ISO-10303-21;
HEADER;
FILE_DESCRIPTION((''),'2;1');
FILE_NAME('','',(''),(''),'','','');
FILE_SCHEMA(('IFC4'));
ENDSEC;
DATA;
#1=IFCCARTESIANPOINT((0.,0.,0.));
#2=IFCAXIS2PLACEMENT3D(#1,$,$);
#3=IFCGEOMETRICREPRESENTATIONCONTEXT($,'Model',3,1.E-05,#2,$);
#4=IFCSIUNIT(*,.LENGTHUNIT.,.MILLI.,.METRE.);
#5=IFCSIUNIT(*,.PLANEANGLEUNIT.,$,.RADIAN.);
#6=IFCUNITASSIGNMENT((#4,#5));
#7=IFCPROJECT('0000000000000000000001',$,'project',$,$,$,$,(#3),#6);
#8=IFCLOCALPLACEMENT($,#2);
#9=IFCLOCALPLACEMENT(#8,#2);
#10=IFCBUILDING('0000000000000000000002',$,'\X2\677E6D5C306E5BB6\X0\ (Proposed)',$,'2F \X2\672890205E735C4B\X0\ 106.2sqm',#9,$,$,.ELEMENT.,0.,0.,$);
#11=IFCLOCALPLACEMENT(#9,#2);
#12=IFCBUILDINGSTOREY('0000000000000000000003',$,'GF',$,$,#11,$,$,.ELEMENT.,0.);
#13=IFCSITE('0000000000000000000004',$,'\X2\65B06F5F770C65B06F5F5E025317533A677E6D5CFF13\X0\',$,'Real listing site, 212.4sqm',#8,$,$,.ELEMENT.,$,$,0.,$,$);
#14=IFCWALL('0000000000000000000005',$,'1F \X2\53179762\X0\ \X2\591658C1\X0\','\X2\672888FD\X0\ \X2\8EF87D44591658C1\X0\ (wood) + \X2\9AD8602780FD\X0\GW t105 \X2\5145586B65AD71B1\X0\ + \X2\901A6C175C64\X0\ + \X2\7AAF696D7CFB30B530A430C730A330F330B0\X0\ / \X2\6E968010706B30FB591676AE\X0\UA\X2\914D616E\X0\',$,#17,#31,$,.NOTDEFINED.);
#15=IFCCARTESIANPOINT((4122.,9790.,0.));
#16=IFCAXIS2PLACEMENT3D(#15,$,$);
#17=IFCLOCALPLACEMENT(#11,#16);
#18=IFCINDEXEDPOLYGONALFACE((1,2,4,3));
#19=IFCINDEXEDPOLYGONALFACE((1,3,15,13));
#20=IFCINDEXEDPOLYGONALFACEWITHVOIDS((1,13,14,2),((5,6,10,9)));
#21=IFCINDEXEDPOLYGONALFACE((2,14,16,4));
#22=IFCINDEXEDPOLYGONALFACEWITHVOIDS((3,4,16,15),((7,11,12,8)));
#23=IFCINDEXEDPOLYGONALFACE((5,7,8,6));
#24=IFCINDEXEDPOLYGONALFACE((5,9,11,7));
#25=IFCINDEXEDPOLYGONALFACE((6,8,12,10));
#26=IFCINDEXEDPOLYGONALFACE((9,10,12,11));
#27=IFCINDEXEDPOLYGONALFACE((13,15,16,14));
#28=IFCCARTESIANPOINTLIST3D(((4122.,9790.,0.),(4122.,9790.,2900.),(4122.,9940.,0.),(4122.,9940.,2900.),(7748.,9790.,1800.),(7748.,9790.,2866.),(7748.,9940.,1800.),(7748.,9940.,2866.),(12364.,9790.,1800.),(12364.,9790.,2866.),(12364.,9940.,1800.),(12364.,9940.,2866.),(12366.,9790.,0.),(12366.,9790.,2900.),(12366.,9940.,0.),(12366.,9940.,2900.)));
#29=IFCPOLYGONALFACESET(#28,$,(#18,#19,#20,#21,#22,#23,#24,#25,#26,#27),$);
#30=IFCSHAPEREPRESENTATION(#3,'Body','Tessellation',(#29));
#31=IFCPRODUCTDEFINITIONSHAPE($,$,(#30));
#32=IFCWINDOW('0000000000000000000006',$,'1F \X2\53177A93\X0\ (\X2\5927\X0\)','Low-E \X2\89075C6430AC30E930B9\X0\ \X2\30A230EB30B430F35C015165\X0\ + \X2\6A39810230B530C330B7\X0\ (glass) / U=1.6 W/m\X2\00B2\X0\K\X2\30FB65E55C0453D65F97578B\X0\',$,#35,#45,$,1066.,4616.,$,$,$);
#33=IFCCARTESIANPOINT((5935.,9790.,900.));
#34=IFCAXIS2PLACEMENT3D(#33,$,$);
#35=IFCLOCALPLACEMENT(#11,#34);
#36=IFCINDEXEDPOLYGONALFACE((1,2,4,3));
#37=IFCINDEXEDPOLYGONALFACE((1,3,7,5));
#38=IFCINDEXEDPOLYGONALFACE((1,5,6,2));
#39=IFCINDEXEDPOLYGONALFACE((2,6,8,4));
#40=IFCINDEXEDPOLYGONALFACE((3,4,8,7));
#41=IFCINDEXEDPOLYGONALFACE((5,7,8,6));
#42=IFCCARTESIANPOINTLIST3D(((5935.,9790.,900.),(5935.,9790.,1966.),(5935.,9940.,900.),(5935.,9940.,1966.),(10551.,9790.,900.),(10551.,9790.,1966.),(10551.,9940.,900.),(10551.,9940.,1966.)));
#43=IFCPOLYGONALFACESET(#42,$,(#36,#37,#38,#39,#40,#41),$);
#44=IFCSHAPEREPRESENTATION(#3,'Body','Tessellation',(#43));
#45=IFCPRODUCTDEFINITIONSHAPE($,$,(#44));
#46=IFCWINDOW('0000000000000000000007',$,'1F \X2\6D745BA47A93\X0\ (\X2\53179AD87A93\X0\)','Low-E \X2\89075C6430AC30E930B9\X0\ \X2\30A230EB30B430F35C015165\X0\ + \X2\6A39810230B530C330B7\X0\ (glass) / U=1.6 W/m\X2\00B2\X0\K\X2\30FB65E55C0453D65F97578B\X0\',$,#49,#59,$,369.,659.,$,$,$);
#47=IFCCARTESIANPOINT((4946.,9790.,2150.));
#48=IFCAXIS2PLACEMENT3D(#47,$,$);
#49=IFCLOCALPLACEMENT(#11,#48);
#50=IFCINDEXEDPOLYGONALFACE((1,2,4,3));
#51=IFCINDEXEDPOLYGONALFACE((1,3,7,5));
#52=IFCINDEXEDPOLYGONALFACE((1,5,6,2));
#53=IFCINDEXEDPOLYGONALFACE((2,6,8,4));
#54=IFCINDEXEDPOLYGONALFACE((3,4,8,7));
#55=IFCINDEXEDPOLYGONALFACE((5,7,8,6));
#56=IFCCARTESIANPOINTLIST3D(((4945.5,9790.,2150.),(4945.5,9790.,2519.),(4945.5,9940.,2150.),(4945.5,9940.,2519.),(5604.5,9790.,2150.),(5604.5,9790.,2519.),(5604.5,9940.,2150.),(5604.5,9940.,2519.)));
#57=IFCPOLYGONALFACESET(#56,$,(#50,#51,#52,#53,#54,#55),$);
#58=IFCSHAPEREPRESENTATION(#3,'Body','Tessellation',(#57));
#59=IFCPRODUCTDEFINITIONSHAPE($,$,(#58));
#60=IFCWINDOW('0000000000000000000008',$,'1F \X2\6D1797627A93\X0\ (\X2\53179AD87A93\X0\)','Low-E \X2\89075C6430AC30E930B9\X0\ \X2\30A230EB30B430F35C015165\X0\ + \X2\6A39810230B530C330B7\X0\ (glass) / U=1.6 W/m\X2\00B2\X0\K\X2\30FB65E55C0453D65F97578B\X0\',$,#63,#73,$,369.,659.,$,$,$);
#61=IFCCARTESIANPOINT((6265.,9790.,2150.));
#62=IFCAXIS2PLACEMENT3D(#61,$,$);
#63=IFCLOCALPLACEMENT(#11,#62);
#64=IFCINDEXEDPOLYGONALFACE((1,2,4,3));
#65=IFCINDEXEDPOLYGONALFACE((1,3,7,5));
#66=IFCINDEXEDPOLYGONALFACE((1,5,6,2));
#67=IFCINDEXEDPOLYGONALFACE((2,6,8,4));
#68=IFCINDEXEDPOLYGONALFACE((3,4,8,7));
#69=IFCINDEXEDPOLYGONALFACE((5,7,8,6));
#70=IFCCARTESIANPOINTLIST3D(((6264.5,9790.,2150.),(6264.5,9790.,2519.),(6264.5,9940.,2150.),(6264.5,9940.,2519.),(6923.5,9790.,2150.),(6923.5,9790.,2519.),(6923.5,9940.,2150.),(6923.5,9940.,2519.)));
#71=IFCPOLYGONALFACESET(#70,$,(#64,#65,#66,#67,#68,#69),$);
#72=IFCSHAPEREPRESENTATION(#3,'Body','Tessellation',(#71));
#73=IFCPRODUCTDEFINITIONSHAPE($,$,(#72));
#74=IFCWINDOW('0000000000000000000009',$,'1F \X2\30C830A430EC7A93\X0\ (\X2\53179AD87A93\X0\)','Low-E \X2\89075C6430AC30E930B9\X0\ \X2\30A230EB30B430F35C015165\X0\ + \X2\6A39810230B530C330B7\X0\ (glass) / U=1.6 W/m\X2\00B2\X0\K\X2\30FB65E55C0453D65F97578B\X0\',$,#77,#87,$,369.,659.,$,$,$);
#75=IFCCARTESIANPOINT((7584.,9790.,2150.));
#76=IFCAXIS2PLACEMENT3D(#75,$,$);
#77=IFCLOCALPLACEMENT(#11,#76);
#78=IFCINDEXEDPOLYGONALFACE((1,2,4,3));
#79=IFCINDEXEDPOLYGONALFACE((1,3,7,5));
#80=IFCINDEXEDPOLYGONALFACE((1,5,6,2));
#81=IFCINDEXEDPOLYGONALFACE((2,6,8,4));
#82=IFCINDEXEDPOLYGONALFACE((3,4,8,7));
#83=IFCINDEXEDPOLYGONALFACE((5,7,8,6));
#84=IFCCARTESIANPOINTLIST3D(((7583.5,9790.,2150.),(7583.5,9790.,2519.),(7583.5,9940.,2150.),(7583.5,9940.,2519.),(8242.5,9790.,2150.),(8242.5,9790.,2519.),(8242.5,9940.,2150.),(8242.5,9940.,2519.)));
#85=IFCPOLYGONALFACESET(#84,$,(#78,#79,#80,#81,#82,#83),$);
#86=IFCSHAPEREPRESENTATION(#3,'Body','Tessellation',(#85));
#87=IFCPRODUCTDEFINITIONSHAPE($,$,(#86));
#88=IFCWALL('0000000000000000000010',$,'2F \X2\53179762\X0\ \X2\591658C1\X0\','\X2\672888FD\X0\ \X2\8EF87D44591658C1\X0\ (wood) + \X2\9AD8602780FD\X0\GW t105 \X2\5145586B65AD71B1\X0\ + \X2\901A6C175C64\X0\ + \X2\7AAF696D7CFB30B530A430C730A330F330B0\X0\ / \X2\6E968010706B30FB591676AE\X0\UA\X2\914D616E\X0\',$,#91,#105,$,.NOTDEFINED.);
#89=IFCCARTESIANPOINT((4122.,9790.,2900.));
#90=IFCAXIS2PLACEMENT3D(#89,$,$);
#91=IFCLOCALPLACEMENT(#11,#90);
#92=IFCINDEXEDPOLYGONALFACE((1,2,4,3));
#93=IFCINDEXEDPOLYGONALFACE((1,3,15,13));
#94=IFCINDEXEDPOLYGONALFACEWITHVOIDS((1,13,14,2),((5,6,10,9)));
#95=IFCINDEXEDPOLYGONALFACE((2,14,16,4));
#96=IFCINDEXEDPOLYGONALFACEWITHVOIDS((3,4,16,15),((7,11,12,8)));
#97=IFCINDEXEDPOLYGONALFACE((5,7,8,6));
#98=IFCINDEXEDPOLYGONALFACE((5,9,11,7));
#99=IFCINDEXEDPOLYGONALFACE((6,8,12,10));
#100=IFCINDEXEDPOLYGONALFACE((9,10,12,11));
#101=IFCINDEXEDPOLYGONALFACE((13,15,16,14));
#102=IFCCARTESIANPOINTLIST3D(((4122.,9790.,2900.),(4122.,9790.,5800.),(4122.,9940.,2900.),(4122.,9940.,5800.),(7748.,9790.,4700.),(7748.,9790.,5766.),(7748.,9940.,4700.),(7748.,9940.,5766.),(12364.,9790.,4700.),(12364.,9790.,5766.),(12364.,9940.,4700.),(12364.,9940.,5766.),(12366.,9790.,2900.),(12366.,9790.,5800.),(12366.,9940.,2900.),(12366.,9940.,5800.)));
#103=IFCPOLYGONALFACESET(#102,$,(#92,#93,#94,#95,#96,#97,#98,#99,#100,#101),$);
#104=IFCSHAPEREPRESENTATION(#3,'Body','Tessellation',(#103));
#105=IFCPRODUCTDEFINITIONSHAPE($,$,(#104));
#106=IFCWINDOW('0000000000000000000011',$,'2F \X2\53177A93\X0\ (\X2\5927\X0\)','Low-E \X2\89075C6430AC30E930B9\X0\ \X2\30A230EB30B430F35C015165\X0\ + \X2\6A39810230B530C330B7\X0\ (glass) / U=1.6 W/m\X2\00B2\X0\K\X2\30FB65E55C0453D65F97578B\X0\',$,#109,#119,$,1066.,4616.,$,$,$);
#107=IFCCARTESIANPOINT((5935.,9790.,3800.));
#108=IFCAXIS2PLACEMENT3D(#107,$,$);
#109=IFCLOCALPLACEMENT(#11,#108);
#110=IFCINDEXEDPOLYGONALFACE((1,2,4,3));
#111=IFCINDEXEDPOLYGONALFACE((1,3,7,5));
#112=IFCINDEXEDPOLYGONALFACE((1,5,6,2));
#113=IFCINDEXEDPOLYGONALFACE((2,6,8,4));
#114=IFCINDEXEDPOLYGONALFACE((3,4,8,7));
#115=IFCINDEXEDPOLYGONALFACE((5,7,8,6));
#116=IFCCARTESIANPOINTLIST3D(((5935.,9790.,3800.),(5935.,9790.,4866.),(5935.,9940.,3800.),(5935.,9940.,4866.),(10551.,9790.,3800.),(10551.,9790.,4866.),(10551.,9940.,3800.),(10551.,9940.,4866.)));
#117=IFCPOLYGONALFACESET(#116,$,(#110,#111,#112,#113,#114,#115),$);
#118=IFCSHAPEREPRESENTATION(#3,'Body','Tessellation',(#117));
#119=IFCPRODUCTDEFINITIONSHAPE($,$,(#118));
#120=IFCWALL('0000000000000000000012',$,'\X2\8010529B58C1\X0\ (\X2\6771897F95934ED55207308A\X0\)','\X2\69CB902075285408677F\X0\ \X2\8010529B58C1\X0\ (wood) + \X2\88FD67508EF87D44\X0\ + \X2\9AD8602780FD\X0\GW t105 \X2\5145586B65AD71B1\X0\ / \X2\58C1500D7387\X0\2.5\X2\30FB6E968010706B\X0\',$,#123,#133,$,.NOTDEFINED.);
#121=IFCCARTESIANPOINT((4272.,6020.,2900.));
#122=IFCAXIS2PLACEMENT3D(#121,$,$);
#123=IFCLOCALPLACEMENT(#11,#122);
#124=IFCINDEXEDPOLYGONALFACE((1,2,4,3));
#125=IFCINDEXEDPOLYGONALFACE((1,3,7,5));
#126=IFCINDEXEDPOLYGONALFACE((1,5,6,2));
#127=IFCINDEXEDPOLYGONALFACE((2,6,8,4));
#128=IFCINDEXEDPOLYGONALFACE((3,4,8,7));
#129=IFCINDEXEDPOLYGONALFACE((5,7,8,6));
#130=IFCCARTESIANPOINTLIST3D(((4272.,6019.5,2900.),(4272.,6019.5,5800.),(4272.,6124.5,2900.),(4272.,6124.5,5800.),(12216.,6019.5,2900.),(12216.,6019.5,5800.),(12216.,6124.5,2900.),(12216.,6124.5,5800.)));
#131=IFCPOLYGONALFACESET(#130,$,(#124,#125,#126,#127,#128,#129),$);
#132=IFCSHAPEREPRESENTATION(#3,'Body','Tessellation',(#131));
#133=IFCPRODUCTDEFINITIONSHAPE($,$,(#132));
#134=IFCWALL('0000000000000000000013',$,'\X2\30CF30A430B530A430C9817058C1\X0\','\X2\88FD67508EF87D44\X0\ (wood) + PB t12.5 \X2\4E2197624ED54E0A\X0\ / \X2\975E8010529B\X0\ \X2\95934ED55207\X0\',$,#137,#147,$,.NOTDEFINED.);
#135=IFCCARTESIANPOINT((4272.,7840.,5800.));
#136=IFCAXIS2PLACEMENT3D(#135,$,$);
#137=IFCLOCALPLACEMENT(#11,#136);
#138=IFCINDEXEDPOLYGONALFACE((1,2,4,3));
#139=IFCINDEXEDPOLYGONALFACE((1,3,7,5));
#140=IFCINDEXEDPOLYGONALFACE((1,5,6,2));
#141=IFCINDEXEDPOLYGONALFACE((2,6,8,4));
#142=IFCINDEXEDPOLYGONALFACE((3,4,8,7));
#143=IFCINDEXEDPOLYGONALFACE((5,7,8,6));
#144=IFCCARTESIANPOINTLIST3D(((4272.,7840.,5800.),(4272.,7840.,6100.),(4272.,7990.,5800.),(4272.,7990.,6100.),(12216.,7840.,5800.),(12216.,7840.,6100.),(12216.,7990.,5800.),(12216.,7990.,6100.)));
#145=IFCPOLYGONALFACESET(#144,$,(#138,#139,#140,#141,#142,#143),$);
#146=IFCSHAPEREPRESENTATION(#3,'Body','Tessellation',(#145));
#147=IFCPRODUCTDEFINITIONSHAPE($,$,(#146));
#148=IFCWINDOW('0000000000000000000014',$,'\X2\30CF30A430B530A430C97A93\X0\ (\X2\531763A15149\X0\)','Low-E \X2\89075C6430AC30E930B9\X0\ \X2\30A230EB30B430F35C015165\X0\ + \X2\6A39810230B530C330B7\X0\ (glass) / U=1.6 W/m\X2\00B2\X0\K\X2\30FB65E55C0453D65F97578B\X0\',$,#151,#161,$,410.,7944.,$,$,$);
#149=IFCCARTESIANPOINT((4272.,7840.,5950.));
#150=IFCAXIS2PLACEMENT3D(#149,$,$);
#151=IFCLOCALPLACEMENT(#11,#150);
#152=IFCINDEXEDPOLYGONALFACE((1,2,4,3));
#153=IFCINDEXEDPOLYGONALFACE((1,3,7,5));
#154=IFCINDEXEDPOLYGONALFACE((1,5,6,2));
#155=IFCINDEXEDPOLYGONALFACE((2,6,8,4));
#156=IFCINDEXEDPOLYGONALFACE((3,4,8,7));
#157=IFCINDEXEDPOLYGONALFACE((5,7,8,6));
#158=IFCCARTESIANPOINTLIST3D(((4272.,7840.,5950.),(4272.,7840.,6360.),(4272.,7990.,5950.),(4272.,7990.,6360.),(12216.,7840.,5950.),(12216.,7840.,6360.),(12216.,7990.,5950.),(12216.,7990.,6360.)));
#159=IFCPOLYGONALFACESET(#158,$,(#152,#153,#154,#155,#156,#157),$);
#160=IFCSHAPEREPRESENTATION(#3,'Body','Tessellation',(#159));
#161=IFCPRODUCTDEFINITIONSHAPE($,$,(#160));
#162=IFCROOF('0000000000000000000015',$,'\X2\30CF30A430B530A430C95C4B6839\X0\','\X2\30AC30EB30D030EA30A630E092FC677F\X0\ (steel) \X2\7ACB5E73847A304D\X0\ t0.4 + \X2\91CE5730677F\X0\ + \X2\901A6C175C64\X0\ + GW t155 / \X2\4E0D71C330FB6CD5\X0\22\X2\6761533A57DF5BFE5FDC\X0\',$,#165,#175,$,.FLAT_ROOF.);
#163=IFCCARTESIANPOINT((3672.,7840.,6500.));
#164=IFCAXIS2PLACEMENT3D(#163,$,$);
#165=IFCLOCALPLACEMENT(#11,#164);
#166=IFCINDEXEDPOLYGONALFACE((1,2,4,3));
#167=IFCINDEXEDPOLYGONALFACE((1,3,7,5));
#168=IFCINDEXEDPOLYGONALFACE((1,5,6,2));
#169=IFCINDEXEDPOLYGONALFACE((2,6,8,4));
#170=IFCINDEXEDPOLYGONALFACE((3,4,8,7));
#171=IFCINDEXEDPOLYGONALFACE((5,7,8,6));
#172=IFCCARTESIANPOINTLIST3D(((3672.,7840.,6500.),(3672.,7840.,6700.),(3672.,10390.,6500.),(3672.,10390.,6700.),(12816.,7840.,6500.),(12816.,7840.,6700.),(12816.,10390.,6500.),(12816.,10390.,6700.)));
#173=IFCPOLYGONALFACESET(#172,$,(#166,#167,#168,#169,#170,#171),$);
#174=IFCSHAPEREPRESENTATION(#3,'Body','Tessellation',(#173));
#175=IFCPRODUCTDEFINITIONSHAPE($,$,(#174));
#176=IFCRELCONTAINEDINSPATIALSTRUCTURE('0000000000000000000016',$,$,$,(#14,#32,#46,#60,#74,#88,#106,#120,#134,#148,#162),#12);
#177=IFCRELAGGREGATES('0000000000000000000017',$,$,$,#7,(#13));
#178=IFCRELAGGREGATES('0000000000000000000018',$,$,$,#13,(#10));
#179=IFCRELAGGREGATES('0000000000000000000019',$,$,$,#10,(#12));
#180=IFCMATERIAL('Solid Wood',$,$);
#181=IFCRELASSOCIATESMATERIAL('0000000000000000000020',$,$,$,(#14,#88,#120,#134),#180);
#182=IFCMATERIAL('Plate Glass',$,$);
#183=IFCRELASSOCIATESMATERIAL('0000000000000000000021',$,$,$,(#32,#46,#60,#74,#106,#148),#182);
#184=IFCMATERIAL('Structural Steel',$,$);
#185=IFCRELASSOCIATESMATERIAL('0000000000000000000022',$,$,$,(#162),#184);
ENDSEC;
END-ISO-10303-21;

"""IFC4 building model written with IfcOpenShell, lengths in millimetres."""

from ifc_helpers import new_model, si_unit, frame, frame_2d, origin, place, context, project, spatial, rectangle, extrude, material, element, fill, save


model = new_model("IFC4")

# Units and contexts
model_context = context("Model", 3, precision=1e-05, world=origin())
ifc_project = project(units=[si_unit("LENGTHUNIT", "METRE", prefix="MILLI"), si_unit("PLANEANGLEUNIT", "RADIAN")], contexts=[model_context])

# Site, building, storey
site_placement = place(None, origin())
site = spatial("IfcSite", under=ifc_project, at=site_placement, Name="新潟県新潟市北区松浜３", ObjectType="Real listing site, 212.4sqm", CompositionType="ELEMENT", RefElevation=0.0)
building_placement = place(site_placement, origin())
building = spatial("IfcBuilding", under=site, at=building_placement, Name="松浜の家 (Proposed)", ObjectType="2F 木造平屋 106.2sqm", CompositionType="ELEMENT", ElevationOfRefHeight=0.0, ElevationOfTerrain=0.0)
storey_placement = place(building_placement, origin())
storey = spatial("IfcBuildingStorey", under=building, at=storey_placement, Name="GF", CompositionType="ELEMENT", Elevation=0.0)

# Wall, openings, windows
ifc_material_1 = material(Name="Solid Wood")
wall_1_placement = place(storey_placement, frame((4122.0, 9790.0, 0.0)))
wall_1 = element("IfcWall", 1, at=wall_1_placement, inside=storey, material=ifc_material_1, Name="1F 北面 外壁", Description="木製 軸組外壁 (wood) + 高性能GW t105 充填断熱 + 通気層 + 窯業系サイディング / 準耐火・外皮UA配慮", PredefinedType="NOTDEFINED", context=model_context, shape_type="SweptSolid", body=[
    extrude(rectangle(XDim=8244.0, YDim=150.0, at=frame_2d((4122.0, 75.0))), frame((4122.0, 9790.0, 0.0)), (0.0, 0.0, 1.0), 2900.0),
])
opening_1_placement = place(storey_placement, frame((5935.0, 9790.0, 900.0)))
opening_1 = element("IfcOpeningElement", 2, at=opening_1_placement, cuts=wall_1, PredefinedType="NOTDEFINED", context=model_context, shape_type="SweptSolid", body=[
    extrude(rectangle(XDim=4616.0, YDim=150.0, at=frame_2d((2308.0, 75.0))), frame((5935.0, 9790.0, 900.0)), (0.0, 0.0, 1.0), 1066.0),
])
opening_2_placement = place(storey_placement, frame((4946.0, 9790.0, 2150.0)))
opening_2 = element("IfcOpeningElement", 3, at=opening_2_placement, cuts=wall_1, PredefinedType="NOTDEFINED", context=model_context, shape_type="SweptSolid", body=[
    extrude(rectangle(XDim=659.0, YDim=150.0, at=frame_2d((329.0, 75.0))), frame((4946.0, 9790.0, 2150.0)), (0.0, 0.0, 1.0), 369.0),
])
opening_3_placement = place(storey_placement, frame((6265.0, 9790.0, 2150.0)))
opening_3 = element("IfcOpeningElement", 4, at=opening_3_placement, cuts=wall_1, PredefinedType="NOTDEFINED", context=model_context, shape_type="SweptSolid", body=[
    extrude(rectangle(XDim=659.0, YDim=150.0, at=frame_2d((329.0, 75.0))), frame((6265.0, 9790.0, 2150.0)), (0.0, 0.0, 1.0), 369.0),
])
opening_4_placement = place(storey_placement, frame((7584.0, 9790.0, 2150.0)))
opening_4 = element("IfcOpeningElement", 5, at=opening_4_placement, cuts=wall_1, PredefinedType="NOTDEFINED", context=model_context, shape_type="SweptSolid", body=[
    extrude(rectangle(XDim=659.0, YDim=150.0, at=frame_2d((329.0, 75.0))), frame((7584.0, 9790.0, 2150.0)), (0.0, 0.0, 1.0), 369.0),
])
ifc_material_2 = material(Name="Plate Glass")
window_1_placement = place(storey_placement, frame((5935.0, 9790.0, 900.0)))
window_1 = element("IfcWindow", 6, at=window_1_placement, inside=storey, material=ifc_material_2, Name="1F 北窓 (大)", Description="Low-E 複層ガラス アルゴン封入 + 樹脂サッシ (glass) / U=1.6 W/m²K・日射取得型", OverallHeight=1066.0, OverallWidth=4616.0, context=model_context, shape_type="SweptSolid", body=[
    extrude(rectangle(XDim=4616.0, YDim=150.0, at=frame_2d((2308.0, 75.0))), frame((5935.0, 9790.0, 900.0)), (0.0, 0.0, 1.0), 1066.0),
])
fill(opening_1, window_1)
window_2_placement = place(storey_placement, frame((4946.0, 9790.0, 2150.0)))
window_2 = element("IfcWindow", 7, at=window_2_placement, inside=storey, material=ifc_material_2, Name="1F 浴室窓 (北高窓)", Description="Low-E 複層ガラス アルゴン封入 + 樹脂サッシ (glass) / U=1.6 W/m²K・日射取得型", OverallHeight=369.0, OverallWidth=659.0, context=model_context, shape_type="SweptSolid", body=[
    extrude(rectangle(XDim=659.0, YDim=150.0, at=frame_2d((329.0, 75.0))), frame((4946.0, 9790.0, 2150.0)), (0.0, 0.0, 1.0), 369.0),
])
fill(opening_2, window_2)
window_3_placement = place(storey_placement, frame((6265.0, 9790.0, 2150.0)))
window_3 = element("IfcWindow", 8, at=window_3_placement, inside=storey, material=ifc_material_2, Name="1F 洗面窓 (北高窓)", Description="Low-E 複層ガラス アルゴン封入 + 樹脂サッシ (glass) / U=1.6 W/m²K・日射取得型", OverallHeight=369.0, OverallWidth=659.0, context=model_context, shape_type="SweptSolid", body=[
    extrude(rectangle(XDim=659.0, YDim=150.0, at=frame_2d((329.0, 75.0))), frame((6265.0, 9790.0, 2150.0)), (0.0, 0.0, 1.0), 369.0),
])
fill(opening_3, window_3)
window_4_placement = place(storey_placement, frame((7584.0, 9790.0, 2150.0)))
window_4 = element("IfcWindow", 9, at=window_4_placement, inside=storey, material=ifc_material_2, Name="1F トイレ窓 (北高窓)", Description="Low-E 複層ガラス アルゴン封入 + 樹脂サッシ (glass) / U=1.6 W/m²K・日射取得型", OverallHeight=369.0, OverallWidth=659.0, context=model_context, shape_type="SweptSolid", body=[
    extrude(rectangle(XDim=659.0, YDim=150.0, at=frame_2d((329.0, 75.0))), frame((7584.0, 9790.0, 2150.0)), (0.0, 0.0, 1.0), 369.0),
])
fill(opening_4, window_4)

# Wall, opening, window
wall_2_placement = place(storey_placement, frame((4122.0, 9790.0, 2900.0)))
wall_2 = element("IfcWall", 10, at=wall_2_placement, inside=storey, material=ifc_material_1, Name="2F 北面 外壁", Description="木製 軸組外壁 (wood) + 高性能GW t105 充填断熱 + 通気層 + 窯業系サイディング / 準耐火・外皮UA配慮", PredefinedType="NOTDEFINED", context=model_context, shape_type="SweptSolid", body=[
    extrude(rectangle(XDim=8244.0, YDim=150.0, at=frame_2d((4122.0, 75.0))), frame((4122.0, 9790.0, 2900.0)), (0.0, 0.0, 1.0), 2900.0),
])
opening_5_placement = place(storey_placement, frame((5935.0, 9790.0, 3800.0)))
opening_5 = element("IfcOpeningElement", 11, at=opening_5_placement, cuts=wall_2, PredefinedType="NOTDEFINED", context=model_context, shape_type="SweptSolid", body=[
    extrude(rectangle(XDim=4616.0, YDim=150.0, at=frame_2d((2308.0, 75.0))), frame((5935.0, 9790.0, 3800.0)), (0.0, 0.0, 1.0), 1066.0),
])
window_5_placement = place(storey_placement, frame((5935.0, 9790.0, 3800.0)))
window_5 = element("IfcWindow", 12, at=window_5_placement, inside=storey, material=ifc_material_2, Name="2F 北窓 (大)", Description="Low-E 複層ガラス アルゴン封入 + 樹脂サッシ (glass) / U=1.6 W/m²K・日射取得型", OverallHeight=1066.0, OverallWidth=4616.0, context=model_context, shape_type="SweptSolid", body=[
    extrude(rectangle(XDim=4616.0, YDim=150.0, at=frame_2d((2308.0, 75.0))), frame((5935.0, 9790.0, 3800.0)), (0.0, 0.0, 1.0), 1066.0),
])
fill(opening_5, window_5)

# Wall
wall_3_placement = place(storey_placement, frame((4272.0, 6020.0, 2900.0)))
element("IfcWall", 13, at=wall_3_placement, inside=storey, material=ifc_material_1, Name="耐力壁 (東西間仕切り)", Description="構造用合板 耐力壁 (wood) + 製材軸組 + 高性能GW t105 充填断熱 / 壁倍率2.5・準耐火", PredefinedType="NOTDEFINED", context=model_context, shape_type="SweptSolid", body=[
    extrude(rectangle(XDim=7944.0, YDim=105.0, at=frame_2d((3972.0, 52.0))), frame((4272.0, 6020.0, 2900.0)), (0.0, 0.0, 1.0), 2900.0),
])

# Wall, opening, window
wall_4_placement = place(storey_placement, frame((4272.0, 7840.0, 5800.0)))
wall_4 = element("IfcWall", 14, at=wall_4_placement, inside=storey, material=ifc_material_1, Name="ハイサイド腰壁", Description="製材軸組 (wood) + PB t12.5 両面仕上 / 非耐力 間仕切", PredefinedType="NOTDEFINED", context=model_context, shape_type="SweptSolid", body=[
    extrude(rectangle(XDim=7944.0, YDim=150.0, at=frame_2d((3972.0, 75.0))), frame((4272.0, 7840.0, 5800.0)), (0.0, 0.0, 1.0), 700.0),
])
opening_6_placement = place(storey_placement, frame((4272.0, 7840.0, 5950.0)))
opening_6 = element("IfcOpeningElement", 15, at=opening_6_placement, cuts=wall_4, PredefinedType="NOTDEFINED", context=model_context, shape_type="SweptSolid", body=[
    extrude(rectangle(XDim=7944.0, YDim=150.0, at=frame_2d((3972.0, 75.0))), frame((4272.0, 7840.0, 5950.0)), (0.0, 0.0, 1.0), 410.0),
])
window_6_placement = place(storey_placement, frame((4272.0, 7840.0, 5950.0)))
window_6 = element("IfcWindow", 16, at=window_6_placement, inside=storey, material=ifc_material_2, Name="ハイサイド窓 (北採光)", Description="Low-E 複層ガラス アルゴン封入 + 樹脂サッシ (glass) / U=1.6 W/m²K・日射取得型", OverallHeight=410.0, OverallWidth=7944.0, context=model_context, shape_type="SweptSolid", body=[
    extrude(rectangle(XDim=7944.0, YDim=150.0, at=frame_2d((3972.0, 75.0))), frame((4272.0, 7840.0, 5950.0)), (0.0, 0.0, 1.0), 410.0),
])
fill(opening_6, window_6)

# Roof
ifc_material_3 = material(Name="Structural Steel")
roof_placement = place(storey_placement, frame((3672.0, 7840.0, 6500.0)))
element("IfcRoof", 17, at=roof_placement, inside=storey, material=ifc_material_3, Name="ハイサイド屋根", Description="ガルバリウム鋼板 (steel) 立平葺き t0.4 + 野地板 + 通気層 + GW t155 / 不燃・法22条区域対応", PredefinedType="FLAT_ROOF", context=model_context, shape_type="SweptSolid", body=[
    extrude(rectangle(XDim=9144.0, YDim=2550.0, at=frame_2d((4572.0, 1275.0))), frame((3672.0, 7840.0, 6500.0)), (0.0, 0.0, 1.0), 200.0),
])

save(model, "model.ifc")
